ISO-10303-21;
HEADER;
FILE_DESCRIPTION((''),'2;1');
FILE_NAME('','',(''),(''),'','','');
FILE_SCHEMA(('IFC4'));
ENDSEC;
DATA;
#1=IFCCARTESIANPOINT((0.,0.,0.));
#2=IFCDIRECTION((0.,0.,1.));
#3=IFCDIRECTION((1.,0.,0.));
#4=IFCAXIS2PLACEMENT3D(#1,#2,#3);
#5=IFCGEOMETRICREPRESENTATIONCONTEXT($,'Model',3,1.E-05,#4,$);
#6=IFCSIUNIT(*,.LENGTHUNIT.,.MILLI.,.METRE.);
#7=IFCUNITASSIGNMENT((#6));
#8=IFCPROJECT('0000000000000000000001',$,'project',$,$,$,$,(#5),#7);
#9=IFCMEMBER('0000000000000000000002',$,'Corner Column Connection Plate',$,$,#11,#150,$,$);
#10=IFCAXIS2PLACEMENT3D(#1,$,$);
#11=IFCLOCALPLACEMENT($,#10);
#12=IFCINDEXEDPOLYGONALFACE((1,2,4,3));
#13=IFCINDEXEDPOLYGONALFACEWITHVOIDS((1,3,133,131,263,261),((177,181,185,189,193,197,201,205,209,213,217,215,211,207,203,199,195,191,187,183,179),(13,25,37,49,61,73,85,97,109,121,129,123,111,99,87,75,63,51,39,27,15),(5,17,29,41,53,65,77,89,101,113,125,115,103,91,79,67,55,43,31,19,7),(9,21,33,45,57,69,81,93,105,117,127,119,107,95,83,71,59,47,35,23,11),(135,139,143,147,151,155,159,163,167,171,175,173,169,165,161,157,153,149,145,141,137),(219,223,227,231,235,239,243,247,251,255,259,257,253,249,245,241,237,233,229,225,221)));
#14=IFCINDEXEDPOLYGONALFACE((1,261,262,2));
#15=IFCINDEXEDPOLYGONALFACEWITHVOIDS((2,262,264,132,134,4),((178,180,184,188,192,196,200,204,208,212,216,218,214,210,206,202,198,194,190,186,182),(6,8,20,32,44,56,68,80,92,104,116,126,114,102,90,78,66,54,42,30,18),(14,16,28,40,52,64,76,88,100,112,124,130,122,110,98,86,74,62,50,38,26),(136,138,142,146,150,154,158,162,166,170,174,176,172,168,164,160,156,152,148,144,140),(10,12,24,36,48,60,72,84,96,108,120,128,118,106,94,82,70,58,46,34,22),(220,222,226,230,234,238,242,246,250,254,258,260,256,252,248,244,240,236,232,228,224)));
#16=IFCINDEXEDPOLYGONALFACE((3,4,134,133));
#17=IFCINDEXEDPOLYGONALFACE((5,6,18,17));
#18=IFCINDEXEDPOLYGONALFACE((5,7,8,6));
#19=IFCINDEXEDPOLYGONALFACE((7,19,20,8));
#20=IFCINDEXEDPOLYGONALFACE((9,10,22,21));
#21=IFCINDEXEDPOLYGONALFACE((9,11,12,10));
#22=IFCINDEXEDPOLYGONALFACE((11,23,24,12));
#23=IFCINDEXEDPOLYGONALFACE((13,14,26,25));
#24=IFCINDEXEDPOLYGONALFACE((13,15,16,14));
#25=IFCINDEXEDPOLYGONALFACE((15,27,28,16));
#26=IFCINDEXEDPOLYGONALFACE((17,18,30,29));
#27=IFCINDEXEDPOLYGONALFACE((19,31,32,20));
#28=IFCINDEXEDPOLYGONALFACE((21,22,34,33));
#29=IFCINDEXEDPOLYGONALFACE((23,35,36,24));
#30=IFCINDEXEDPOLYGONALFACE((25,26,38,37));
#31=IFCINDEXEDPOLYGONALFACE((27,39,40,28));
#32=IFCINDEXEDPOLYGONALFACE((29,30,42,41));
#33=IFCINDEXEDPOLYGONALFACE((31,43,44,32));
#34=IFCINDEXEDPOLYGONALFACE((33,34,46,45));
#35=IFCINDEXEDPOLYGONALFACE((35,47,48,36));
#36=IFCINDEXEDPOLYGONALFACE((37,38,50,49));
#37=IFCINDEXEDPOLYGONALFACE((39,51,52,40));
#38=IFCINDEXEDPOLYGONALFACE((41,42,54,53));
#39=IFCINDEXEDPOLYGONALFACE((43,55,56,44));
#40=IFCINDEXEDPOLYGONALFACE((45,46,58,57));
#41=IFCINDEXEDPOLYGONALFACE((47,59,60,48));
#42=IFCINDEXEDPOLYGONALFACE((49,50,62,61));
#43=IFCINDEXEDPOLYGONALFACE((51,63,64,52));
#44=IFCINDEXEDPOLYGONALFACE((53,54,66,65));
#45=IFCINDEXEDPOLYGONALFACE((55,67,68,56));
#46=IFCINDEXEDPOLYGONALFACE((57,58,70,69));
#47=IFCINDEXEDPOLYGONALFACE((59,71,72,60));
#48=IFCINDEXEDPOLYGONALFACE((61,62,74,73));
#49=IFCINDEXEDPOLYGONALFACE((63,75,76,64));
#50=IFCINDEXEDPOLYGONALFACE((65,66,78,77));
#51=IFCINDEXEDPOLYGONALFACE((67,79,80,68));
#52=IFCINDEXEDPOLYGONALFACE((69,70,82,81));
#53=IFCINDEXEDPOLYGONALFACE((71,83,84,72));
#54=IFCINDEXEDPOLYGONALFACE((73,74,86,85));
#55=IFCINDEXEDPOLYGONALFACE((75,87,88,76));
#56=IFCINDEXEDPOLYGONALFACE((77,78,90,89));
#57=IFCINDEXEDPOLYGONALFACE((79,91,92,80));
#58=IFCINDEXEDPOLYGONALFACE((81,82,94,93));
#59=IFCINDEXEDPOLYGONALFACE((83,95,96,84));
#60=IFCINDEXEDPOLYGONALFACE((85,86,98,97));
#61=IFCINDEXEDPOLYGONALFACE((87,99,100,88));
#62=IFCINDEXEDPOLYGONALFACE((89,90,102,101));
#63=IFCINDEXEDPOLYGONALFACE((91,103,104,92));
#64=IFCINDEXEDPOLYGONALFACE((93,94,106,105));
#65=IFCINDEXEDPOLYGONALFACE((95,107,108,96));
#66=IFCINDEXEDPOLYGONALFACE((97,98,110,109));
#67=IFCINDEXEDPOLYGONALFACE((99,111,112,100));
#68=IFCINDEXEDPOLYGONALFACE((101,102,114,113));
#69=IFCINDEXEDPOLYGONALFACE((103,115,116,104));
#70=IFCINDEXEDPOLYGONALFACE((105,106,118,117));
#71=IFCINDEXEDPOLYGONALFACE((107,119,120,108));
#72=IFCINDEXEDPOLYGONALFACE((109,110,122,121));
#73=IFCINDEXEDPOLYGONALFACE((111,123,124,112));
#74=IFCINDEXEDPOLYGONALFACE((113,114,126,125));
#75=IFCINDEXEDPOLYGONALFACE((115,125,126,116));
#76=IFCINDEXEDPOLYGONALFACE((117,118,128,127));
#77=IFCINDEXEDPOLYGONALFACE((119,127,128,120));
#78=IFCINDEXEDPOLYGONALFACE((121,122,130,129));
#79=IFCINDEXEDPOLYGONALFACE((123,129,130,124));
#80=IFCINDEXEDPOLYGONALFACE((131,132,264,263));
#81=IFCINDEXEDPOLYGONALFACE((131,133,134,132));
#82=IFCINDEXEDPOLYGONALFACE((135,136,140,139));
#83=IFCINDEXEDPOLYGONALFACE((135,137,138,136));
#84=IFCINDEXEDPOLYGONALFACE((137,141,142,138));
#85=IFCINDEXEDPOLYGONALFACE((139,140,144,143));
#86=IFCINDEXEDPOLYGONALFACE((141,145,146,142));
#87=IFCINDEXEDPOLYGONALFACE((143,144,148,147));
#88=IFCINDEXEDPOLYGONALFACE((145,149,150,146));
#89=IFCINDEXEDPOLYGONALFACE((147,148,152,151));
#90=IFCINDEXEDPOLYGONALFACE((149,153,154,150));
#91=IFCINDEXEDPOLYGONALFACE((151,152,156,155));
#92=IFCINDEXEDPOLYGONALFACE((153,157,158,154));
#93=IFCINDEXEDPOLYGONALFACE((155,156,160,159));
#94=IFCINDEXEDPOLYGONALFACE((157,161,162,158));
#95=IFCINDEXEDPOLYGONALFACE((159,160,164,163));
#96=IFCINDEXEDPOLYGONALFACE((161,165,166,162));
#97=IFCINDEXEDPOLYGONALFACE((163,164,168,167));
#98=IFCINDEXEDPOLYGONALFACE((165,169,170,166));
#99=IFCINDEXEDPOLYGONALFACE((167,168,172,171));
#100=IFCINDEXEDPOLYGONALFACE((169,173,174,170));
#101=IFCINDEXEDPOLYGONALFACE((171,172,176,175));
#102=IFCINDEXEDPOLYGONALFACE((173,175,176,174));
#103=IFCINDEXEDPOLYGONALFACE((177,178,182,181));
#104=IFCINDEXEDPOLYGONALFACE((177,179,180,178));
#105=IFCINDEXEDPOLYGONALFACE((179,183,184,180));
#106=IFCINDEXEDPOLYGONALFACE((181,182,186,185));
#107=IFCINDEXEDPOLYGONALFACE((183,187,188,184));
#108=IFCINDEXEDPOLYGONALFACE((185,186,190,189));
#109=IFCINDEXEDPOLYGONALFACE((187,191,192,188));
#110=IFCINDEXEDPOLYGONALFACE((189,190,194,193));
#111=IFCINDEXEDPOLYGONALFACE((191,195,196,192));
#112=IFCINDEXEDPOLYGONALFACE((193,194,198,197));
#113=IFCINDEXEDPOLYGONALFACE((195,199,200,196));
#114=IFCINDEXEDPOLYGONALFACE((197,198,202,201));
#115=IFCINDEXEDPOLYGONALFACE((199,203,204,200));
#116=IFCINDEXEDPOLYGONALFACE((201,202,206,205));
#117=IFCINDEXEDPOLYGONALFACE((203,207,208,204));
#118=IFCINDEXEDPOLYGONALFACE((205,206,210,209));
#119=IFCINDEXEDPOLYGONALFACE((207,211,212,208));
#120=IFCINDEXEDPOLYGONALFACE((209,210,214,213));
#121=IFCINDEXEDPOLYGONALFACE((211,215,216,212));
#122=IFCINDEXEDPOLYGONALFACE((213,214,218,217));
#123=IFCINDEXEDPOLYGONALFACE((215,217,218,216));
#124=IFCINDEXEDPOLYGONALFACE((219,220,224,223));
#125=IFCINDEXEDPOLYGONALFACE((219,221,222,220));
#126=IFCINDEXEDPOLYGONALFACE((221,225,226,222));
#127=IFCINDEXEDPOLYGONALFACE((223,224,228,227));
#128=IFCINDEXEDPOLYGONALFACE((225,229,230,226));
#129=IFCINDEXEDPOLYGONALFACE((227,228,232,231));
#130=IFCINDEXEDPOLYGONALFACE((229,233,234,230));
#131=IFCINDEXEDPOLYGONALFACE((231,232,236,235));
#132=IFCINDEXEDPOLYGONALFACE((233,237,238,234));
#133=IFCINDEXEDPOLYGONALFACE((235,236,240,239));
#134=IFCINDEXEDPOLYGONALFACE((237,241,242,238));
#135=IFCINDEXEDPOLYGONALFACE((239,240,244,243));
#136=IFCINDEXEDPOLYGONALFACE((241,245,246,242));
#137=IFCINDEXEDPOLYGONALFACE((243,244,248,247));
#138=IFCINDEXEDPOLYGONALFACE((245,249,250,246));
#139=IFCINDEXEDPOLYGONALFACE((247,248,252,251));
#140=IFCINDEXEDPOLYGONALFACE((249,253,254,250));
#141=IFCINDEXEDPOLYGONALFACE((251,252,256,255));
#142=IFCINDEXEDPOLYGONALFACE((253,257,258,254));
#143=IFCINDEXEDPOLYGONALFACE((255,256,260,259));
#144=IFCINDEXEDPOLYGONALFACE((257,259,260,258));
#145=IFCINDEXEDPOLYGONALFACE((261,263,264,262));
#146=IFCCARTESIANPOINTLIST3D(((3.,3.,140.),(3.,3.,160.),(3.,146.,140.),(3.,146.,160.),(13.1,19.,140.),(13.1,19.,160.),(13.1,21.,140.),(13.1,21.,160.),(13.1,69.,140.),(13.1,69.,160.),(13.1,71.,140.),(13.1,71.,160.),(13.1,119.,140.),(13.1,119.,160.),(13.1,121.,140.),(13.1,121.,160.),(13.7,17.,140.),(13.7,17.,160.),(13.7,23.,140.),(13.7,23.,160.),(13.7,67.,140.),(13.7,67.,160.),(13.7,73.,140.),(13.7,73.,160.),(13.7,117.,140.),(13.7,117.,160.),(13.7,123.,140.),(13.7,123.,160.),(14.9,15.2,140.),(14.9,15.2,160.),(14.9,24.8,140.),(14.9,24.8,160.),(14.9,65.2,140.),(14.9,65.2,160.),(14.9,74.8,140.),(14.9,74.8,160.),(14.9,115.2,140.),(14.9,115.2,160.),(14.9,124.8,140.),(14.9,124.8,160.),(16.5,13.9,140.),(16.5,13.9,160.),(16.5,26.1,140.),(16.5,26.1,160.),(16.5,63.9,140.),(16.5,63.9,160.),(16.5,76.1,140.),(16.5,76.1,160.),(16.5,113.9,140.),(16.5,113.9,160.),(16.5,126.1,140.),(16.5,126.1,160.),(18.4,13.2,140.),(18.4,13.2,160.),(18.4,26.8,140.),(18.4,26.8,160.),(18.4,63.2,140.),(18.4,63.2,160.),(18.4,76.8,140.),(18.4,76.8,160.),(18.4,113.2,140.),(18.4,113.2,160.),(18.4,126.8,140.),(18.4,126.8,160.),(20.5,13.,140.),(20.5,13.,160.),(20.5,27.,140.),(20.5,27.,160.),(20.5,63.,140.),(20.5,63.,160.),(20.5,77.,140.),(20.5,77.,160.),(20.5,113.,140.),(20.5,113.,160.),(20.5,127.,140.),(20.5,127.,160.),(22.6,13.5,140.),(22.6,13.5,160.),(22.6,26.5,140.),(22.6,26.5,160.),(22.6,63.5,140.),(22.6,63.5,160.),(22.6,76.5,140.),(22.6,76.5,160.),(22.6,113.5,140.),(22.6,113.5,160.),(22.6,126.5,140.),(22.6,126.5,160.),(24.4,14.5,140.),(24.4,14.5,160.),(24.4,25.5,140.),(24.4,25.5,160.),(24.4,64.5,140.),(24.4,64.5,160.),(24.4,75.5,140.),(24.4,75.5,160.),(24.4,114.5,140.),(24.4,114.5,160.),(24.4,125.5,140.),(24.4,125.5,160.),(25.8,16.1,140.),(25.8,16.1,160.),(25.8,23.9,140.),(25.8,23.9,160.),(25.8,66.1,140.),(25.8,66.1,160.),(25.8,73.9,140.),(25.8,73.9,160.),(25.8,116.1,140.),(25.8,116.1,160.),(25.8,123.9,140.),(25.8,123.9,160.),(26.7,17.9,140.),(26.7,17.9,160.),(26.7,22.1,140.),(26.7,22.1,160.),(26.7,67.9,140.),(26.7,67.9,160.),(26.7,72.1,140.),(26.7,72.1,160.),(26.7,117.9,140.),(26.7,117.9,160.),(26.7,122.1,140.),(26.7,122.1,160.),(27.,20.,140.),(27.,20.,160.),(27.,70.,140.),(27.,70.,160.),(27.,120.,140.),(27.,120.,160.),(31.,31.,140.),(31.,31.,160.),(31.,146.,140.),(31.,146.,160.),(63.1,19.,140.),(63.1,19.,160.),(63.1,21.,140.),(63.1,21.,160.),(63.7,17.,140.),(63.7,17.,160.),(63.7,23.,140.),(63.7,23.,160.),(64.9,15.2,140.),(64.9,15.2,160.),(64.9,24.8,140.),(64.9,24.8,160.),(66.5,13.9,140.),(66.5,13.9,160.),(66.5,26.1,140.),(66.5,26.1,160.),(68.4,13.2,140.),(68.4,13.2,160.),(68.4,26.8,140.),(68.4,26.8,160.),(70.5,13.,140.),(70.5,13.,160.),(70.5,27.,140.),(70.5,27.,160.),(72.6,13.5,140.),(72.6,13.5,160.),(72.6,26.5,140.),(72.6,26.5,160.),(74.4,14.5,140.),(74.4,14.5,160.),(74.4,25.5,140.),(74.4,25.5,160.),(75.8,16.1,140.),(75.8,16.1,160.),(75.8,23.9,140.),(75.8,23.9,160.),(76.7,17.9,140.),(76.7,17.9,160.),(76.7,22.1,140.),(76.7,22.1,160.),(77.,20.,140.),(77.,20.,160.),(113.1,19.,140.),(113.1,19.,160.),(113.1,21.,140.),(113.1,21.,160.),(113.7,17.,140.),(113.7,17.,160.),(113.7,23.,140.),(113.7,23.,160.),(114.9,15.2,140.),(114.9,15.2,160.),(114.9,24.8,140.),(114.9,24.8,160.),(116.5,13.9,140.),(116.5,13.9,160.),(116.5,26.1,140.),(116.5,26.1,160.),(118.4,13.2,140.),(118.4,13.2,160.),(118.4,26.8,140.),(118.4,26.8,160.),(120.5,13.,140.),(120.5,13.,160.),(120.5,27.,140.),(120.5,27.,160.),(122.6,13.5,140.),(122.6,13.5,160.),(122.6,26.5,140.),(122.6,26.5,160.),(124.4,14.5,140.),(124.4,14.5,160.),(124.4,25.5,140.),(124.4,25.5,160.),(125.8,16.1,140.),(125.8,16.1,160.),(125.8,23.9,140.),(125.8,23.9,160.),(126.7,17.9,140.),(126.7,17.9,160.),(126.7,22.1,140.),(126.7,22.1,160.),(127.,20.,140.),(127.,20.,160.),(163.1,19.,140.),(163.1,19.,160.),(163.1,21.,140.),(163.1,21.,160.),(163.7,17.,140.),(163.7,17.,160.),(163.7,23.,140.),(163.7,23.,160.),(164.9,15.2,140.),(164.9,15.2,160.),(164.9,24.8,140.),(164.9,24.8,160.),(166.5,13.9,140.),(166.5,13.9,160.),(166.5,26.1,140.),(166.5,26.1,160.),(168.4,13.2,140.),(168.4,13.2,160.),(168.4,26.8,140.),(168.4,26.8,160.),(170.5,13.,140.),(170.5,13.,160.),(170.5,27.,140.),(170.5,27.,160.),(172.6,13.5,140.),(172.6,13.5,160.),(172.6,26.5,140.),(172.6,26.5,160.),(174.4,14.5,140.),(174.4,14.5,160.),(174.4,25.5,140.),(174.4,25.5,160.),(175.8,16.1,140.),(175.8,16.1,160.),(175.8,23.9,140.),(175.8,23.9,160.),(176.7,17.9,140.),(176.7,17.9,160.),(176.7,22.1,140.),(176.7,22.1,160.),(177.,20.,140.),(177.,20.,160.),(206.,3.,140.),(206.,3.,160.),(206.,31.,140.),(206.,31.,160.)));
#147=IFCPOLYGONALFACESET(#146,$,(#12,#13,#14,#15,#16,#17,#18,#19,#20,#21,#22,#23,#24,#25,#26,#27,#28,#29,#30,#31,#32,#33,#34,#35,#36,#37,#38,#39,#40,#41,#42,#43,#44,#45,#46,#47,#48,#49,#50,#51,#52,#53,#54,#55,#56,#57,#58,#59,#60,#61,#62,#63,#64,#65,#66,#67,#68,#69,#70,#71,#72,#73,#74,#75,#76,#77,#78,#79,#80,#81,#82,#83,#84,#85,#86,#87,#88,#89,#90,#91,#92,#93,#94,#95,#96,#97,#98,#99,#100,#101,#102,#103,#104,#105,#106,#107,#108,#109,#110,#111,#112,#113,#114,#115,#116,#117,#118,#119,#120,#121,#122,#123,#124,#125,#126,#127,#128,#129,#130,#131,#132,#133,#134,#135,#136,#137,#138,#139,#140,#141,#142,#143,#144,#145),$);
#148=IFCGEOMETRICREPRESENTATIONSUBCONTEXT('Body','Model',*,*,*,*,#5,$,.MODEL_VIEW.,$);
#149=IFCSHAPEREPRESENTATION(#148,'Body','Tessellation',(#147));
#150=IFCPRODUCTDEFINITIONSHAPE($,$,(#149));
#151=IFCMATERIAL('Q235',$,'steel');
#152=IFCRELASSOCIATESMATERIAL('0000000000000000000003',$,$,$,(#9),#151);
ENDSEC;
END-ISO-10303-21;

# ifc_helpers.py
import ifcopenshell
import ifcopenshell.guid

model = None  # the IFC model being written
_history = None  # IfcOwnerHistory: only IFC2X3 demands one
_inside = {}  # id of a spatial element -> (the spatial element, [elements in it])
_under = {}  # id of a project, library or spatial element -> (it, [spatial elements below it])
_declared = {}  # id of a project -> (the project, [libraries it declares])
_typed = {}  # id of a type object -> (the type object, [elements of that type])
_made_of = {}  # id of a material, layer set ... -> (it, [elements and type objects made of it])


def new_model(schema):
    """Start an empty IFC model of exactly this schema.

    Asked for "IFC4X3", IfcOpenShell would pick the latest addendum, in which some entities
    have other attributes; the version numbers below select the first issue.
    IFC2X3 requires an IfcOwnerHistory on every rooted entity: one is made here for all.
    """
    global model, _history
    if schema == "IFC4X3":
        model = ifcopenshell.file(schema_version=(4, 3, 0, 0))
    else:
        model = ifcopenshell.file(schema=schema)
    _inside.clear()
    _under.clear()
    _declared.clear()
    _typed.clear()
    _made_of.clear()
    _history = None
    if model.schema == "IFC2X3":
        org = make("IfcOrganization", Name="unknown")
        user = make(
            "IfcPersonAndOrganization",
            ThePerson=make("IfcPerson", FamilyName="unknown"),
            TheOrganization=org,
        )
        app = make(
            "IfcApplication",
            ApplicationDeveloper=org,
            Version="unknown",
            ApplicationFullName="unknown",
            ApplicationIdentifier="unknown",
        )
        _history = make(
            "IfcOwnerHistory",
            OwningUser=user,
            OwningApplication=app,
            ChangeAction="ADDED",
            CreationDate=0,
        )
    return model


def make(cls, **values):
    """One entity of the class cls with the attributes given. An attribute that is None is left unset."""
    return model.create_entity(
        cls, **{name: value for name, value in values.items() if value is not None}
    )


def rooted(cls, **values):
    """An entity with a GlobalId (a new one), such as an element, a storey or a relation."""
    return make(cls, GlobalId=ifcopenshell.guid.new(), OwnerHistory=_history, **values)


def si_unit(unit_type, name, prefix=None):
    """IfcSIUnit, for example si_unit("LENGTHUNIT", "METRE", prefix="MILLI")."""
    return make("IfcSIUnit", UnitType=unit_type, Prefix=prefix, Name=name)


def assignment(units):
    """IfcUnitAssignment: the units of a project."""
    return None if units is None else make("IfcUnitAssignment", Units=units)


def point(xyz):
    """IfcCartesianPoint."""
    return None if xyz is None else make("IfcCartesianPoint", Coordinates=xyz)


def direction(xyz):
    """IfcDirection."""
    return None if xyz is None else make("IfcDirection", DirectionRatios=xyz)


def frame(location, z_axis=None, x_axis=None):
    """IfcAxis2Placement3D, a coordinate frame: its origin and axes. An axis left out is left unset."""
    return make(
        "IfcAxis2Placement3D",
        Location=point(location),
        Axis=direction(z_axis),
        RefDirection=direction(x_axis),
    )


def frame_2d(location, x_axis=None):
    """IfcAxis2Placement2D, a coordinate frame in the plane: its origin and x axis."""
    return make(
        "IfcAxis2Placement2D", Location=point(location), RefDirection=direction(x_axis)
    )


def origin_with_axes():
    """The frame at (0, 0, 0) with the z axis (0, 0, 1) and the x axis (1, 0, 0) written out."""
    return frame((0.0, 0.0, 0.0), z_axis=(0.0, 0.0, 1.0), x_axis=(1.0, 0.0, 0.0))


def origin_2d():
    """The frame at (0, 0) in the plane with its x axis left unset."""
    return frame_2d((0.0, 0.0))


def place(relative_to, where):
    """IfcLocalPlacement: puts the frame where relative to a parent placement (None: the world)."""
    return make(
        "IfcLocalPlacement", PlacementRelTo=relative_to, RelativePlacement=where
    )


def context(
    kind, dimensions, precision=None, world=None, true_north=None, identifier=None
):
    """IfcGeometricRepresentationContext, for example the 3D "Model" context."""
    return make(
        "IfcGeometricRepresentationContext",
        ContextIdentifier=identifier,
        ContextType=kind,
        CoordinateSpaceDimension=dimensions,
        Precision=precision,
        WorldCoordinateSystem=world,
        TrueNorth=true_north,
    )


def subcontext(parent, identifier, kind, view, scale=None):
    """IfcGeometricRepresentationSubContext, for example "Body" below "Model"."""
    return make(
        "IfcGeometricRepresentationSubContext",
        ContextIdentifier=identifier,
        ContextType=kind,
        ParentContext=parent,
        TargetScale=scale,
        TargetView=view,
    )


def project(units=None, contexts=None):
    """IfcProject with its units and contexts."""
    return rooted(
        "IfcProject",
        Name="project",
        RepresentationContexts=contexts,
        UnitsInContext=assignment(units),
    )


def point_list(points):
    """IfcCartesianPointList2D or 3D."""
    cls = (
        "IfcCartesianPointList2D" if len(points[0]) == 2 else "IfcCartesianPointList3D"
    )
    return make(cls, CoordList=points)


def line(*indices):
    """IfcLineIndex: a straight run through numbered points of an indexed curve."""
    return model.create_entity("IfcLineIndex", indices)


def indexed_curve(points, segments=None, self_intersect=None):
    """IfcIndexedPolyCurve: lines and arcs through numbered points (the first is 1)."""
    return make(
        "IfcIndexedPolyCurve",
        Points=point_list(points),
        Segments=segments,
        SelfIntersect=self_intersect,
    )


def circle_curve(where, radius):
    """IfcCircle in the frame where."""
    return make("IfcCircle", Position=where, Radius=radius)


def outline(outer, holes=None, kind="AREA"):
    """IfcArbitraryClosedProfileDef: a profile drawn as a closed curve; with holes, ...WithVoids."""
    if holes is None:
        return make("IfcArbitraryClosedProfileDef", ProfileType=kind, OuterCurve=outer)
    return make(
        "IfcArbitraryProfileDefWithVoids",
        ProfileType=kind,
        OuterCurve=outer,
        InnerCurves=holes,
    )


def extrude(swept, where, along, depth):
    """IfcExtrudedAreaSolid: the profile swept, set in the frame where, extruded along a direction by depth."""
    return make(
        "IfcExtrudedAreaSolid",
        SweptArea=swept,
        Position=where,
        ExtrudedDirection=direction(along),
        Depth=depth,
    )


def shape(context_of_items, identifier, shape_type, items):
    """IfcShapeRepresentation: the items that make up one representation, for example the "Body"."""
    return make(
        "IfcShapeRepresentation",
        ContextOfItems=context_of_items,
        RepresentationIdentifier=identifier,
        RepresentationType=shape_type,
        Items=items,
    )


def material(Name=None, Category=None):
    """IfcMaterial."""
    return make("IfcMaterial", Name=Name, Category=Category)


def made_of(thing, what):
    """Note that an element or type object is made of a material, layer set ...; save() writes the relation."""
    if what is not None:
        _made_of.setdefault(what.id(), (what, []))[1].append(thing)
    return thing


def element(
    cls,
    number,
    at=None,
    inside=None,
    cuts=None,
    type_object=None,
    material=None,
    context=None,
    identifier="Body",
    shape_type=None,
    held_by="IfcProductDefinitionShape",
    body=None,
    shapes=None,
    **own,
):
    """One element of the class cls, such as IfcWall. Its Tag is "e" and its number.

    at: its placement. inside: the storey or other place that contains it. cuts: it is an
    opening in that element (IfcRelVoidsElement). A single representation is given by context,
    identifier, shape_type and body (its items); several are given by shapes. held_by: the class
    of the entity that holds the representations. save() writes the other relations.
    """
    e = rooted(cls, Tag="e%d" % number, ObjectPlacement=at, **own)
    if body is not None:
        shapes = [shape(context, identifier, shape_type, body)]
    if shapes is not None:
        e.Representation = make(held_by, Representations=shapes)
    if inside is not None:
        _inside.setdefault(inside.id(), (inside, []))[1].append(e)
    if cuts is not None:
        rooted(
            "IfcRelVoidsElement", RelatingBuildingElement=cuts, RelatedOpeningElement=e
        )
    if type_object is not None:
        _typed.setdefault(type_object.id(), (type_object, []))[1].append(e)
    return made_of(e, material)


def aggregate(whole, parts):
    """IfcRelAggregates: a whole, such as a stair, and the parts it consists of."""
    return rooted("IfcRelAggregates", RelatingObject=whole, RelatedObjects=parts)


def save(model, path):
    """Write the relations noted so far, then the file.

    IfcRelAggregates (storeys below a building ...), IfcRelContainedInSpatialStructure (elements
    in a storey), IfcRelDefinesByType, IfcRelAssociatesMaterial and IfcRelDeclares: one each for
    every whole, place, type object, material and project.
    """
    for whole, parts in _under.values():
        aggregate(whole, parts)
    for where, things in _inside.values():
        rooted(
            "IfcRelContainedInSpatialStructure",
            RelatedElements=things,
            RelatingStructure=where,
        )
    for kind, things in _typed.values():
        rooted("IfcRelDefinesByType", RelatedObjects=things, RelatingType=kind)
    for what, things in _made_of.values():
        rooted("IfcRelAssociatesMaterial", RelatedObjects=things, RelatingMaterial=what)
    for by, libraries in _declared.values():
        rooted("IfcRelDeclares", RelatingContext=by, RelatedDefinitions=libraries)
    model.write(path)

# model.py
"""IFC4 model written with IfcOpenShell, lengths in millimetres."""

from ifc_helpers import new_model, si_unit, frame, origin_with_axes, origin_2d, place, context, subcontext, project, line, indexed_curve, circle_curve, outline, extrude, material, element, save


model = new_model("IFC4")

# Units and contexts
model_context = context("Model", 3, precision=1e-05, world=origin_with_axes())
body_context = subcontext(model_context, "Body", "Model", "MODEL_VIEW")
ifc_project = project(units=[si_unit("LENGTHUNIT", "METRE", prefix="MILLI")], contexts=[model_context])

# Member, openings
ifc_material_1 = material(Name="Q235", Category="steel")
member_1_placement = place(None, frame((3.0, 3.0, 140.0), z_axis=(0.0, 0.0, 1.0), x_axis=(1.0, 0.0, 0.0)))
member_1 = element("IfcMember", 1, at=member_1_placement, material=ifc_material_1, Name="Corner Column Connection Plate", context=body_context, shape_type="SweptSolid", body=[
    extrude(outline(indexed_curve([(0.0, 0.0), (203.0, 0.0), (203.0, 28.0), (28.0, 28.0), (28.0, 143.0), (0.0, 143.0), (0.0, 0.0)], segments=[line(1, 2, 3, 4, 5, 6, 7, 1)])), origin_with_axes(), (0.0, 0.0, 1.0), 20.0),
])
opening_1_placement = place(member_1_placement, frame((17.0, 17.0, 0.0), z_axis=(0.0, 0.0, 1.0), x_axis=(1.0, 0.0, 0.0)))
element("IfcOpeningElement", 2, at=opening_1_placement, cuts=member_1, context=body_context, shape_type="SweptSolid", body=[
    extrude(outline(circle_curve(origin_2d(), 7.0)), origin_with_axes(), (0.0, 0.0, 1.0), 20.0),
])
opening_2_placement = place(member_1_placement, frame((67.0, 17.0, 0.0), z_axis=(0.0, 0.0, 1.0), x_axis=(1.0, 0.0, 0.0)))
element("IfcOpeningElement", 3, at=opening_2_placement, cuts=member_1, context=body_context, shape_type="SweptSolid", body=[
    extrude(outline(circle_curve(origin_2d(), 7.0)), origin_with_axes(), (0.0, 0.0, 1.0), 20.0),
])
opening_3_placement = place(member_1_placement, frame((117.0, 17.0, 0.0), z_axis=(0.0, 0.0, 1.0), x_axis=(1.0, 0.0, 0.0)))
element("IfcOpeningElement", 4, at=opening_3_placement, cuts=member_1, context=body_context, shape_type="SweptSolid", body=[
    extrude(outline(circle_curve(origin_2d(), 7.0)), origin_with_axes(), (0.0, 0.0, 1.0), 20.0),
])
opening_4_placement = place(member_1_placement, frame((167.0, 17.0, 0.0), z_axis=(0.0, 0.0, 1.0), x_axis=(1.0, 0.0, 0.0)))
element("IfcOpeningElement", 5, at=opening_4_placement, cuts=member_1, context=body_context, shape_type="SweptSolid", body=[
    extrude(outline(circle_curve(origin_2d(), 7.0)), origin_with_axes(), (0.0, 0.0, 1.0), 20.0),
])
opening_5_placement = place(member_1_placement, frame((17.0, 67.0, 0.0), z_axis=(0.0, 0.0, 1.0), x_axis=(1.0, 0.0, 0.0)))
element("IfcOpeningElement", 6, at=opening_5_placement, cuts=member_1, context=body_context, shape_type="SweptSolid", body=[
    extrude(outline(circle_curve(origin_2d(), 7.0)), origin_with_axes(), (0.0, 0.0, 1.0), 20.0),
])
opening_6_placement = place(member_1_placement, frame((17.0, 117.0, 0.0), z_axis=(0.0, 0.0, 1.0), x_axis=(1.0, 0.0, 0.0)))
element("IfcOpeningElement", 7, at=opening_6_placement, cuts=member_1, context=body_context, shape_type="SweptSolid", body=[
    extrude(outline(circle_curve(origin_2d(), 7.0)), origin_with_axes(), (0.0, 0.0, 1.0), 20.0),
])

save(model, "model.ifc")
